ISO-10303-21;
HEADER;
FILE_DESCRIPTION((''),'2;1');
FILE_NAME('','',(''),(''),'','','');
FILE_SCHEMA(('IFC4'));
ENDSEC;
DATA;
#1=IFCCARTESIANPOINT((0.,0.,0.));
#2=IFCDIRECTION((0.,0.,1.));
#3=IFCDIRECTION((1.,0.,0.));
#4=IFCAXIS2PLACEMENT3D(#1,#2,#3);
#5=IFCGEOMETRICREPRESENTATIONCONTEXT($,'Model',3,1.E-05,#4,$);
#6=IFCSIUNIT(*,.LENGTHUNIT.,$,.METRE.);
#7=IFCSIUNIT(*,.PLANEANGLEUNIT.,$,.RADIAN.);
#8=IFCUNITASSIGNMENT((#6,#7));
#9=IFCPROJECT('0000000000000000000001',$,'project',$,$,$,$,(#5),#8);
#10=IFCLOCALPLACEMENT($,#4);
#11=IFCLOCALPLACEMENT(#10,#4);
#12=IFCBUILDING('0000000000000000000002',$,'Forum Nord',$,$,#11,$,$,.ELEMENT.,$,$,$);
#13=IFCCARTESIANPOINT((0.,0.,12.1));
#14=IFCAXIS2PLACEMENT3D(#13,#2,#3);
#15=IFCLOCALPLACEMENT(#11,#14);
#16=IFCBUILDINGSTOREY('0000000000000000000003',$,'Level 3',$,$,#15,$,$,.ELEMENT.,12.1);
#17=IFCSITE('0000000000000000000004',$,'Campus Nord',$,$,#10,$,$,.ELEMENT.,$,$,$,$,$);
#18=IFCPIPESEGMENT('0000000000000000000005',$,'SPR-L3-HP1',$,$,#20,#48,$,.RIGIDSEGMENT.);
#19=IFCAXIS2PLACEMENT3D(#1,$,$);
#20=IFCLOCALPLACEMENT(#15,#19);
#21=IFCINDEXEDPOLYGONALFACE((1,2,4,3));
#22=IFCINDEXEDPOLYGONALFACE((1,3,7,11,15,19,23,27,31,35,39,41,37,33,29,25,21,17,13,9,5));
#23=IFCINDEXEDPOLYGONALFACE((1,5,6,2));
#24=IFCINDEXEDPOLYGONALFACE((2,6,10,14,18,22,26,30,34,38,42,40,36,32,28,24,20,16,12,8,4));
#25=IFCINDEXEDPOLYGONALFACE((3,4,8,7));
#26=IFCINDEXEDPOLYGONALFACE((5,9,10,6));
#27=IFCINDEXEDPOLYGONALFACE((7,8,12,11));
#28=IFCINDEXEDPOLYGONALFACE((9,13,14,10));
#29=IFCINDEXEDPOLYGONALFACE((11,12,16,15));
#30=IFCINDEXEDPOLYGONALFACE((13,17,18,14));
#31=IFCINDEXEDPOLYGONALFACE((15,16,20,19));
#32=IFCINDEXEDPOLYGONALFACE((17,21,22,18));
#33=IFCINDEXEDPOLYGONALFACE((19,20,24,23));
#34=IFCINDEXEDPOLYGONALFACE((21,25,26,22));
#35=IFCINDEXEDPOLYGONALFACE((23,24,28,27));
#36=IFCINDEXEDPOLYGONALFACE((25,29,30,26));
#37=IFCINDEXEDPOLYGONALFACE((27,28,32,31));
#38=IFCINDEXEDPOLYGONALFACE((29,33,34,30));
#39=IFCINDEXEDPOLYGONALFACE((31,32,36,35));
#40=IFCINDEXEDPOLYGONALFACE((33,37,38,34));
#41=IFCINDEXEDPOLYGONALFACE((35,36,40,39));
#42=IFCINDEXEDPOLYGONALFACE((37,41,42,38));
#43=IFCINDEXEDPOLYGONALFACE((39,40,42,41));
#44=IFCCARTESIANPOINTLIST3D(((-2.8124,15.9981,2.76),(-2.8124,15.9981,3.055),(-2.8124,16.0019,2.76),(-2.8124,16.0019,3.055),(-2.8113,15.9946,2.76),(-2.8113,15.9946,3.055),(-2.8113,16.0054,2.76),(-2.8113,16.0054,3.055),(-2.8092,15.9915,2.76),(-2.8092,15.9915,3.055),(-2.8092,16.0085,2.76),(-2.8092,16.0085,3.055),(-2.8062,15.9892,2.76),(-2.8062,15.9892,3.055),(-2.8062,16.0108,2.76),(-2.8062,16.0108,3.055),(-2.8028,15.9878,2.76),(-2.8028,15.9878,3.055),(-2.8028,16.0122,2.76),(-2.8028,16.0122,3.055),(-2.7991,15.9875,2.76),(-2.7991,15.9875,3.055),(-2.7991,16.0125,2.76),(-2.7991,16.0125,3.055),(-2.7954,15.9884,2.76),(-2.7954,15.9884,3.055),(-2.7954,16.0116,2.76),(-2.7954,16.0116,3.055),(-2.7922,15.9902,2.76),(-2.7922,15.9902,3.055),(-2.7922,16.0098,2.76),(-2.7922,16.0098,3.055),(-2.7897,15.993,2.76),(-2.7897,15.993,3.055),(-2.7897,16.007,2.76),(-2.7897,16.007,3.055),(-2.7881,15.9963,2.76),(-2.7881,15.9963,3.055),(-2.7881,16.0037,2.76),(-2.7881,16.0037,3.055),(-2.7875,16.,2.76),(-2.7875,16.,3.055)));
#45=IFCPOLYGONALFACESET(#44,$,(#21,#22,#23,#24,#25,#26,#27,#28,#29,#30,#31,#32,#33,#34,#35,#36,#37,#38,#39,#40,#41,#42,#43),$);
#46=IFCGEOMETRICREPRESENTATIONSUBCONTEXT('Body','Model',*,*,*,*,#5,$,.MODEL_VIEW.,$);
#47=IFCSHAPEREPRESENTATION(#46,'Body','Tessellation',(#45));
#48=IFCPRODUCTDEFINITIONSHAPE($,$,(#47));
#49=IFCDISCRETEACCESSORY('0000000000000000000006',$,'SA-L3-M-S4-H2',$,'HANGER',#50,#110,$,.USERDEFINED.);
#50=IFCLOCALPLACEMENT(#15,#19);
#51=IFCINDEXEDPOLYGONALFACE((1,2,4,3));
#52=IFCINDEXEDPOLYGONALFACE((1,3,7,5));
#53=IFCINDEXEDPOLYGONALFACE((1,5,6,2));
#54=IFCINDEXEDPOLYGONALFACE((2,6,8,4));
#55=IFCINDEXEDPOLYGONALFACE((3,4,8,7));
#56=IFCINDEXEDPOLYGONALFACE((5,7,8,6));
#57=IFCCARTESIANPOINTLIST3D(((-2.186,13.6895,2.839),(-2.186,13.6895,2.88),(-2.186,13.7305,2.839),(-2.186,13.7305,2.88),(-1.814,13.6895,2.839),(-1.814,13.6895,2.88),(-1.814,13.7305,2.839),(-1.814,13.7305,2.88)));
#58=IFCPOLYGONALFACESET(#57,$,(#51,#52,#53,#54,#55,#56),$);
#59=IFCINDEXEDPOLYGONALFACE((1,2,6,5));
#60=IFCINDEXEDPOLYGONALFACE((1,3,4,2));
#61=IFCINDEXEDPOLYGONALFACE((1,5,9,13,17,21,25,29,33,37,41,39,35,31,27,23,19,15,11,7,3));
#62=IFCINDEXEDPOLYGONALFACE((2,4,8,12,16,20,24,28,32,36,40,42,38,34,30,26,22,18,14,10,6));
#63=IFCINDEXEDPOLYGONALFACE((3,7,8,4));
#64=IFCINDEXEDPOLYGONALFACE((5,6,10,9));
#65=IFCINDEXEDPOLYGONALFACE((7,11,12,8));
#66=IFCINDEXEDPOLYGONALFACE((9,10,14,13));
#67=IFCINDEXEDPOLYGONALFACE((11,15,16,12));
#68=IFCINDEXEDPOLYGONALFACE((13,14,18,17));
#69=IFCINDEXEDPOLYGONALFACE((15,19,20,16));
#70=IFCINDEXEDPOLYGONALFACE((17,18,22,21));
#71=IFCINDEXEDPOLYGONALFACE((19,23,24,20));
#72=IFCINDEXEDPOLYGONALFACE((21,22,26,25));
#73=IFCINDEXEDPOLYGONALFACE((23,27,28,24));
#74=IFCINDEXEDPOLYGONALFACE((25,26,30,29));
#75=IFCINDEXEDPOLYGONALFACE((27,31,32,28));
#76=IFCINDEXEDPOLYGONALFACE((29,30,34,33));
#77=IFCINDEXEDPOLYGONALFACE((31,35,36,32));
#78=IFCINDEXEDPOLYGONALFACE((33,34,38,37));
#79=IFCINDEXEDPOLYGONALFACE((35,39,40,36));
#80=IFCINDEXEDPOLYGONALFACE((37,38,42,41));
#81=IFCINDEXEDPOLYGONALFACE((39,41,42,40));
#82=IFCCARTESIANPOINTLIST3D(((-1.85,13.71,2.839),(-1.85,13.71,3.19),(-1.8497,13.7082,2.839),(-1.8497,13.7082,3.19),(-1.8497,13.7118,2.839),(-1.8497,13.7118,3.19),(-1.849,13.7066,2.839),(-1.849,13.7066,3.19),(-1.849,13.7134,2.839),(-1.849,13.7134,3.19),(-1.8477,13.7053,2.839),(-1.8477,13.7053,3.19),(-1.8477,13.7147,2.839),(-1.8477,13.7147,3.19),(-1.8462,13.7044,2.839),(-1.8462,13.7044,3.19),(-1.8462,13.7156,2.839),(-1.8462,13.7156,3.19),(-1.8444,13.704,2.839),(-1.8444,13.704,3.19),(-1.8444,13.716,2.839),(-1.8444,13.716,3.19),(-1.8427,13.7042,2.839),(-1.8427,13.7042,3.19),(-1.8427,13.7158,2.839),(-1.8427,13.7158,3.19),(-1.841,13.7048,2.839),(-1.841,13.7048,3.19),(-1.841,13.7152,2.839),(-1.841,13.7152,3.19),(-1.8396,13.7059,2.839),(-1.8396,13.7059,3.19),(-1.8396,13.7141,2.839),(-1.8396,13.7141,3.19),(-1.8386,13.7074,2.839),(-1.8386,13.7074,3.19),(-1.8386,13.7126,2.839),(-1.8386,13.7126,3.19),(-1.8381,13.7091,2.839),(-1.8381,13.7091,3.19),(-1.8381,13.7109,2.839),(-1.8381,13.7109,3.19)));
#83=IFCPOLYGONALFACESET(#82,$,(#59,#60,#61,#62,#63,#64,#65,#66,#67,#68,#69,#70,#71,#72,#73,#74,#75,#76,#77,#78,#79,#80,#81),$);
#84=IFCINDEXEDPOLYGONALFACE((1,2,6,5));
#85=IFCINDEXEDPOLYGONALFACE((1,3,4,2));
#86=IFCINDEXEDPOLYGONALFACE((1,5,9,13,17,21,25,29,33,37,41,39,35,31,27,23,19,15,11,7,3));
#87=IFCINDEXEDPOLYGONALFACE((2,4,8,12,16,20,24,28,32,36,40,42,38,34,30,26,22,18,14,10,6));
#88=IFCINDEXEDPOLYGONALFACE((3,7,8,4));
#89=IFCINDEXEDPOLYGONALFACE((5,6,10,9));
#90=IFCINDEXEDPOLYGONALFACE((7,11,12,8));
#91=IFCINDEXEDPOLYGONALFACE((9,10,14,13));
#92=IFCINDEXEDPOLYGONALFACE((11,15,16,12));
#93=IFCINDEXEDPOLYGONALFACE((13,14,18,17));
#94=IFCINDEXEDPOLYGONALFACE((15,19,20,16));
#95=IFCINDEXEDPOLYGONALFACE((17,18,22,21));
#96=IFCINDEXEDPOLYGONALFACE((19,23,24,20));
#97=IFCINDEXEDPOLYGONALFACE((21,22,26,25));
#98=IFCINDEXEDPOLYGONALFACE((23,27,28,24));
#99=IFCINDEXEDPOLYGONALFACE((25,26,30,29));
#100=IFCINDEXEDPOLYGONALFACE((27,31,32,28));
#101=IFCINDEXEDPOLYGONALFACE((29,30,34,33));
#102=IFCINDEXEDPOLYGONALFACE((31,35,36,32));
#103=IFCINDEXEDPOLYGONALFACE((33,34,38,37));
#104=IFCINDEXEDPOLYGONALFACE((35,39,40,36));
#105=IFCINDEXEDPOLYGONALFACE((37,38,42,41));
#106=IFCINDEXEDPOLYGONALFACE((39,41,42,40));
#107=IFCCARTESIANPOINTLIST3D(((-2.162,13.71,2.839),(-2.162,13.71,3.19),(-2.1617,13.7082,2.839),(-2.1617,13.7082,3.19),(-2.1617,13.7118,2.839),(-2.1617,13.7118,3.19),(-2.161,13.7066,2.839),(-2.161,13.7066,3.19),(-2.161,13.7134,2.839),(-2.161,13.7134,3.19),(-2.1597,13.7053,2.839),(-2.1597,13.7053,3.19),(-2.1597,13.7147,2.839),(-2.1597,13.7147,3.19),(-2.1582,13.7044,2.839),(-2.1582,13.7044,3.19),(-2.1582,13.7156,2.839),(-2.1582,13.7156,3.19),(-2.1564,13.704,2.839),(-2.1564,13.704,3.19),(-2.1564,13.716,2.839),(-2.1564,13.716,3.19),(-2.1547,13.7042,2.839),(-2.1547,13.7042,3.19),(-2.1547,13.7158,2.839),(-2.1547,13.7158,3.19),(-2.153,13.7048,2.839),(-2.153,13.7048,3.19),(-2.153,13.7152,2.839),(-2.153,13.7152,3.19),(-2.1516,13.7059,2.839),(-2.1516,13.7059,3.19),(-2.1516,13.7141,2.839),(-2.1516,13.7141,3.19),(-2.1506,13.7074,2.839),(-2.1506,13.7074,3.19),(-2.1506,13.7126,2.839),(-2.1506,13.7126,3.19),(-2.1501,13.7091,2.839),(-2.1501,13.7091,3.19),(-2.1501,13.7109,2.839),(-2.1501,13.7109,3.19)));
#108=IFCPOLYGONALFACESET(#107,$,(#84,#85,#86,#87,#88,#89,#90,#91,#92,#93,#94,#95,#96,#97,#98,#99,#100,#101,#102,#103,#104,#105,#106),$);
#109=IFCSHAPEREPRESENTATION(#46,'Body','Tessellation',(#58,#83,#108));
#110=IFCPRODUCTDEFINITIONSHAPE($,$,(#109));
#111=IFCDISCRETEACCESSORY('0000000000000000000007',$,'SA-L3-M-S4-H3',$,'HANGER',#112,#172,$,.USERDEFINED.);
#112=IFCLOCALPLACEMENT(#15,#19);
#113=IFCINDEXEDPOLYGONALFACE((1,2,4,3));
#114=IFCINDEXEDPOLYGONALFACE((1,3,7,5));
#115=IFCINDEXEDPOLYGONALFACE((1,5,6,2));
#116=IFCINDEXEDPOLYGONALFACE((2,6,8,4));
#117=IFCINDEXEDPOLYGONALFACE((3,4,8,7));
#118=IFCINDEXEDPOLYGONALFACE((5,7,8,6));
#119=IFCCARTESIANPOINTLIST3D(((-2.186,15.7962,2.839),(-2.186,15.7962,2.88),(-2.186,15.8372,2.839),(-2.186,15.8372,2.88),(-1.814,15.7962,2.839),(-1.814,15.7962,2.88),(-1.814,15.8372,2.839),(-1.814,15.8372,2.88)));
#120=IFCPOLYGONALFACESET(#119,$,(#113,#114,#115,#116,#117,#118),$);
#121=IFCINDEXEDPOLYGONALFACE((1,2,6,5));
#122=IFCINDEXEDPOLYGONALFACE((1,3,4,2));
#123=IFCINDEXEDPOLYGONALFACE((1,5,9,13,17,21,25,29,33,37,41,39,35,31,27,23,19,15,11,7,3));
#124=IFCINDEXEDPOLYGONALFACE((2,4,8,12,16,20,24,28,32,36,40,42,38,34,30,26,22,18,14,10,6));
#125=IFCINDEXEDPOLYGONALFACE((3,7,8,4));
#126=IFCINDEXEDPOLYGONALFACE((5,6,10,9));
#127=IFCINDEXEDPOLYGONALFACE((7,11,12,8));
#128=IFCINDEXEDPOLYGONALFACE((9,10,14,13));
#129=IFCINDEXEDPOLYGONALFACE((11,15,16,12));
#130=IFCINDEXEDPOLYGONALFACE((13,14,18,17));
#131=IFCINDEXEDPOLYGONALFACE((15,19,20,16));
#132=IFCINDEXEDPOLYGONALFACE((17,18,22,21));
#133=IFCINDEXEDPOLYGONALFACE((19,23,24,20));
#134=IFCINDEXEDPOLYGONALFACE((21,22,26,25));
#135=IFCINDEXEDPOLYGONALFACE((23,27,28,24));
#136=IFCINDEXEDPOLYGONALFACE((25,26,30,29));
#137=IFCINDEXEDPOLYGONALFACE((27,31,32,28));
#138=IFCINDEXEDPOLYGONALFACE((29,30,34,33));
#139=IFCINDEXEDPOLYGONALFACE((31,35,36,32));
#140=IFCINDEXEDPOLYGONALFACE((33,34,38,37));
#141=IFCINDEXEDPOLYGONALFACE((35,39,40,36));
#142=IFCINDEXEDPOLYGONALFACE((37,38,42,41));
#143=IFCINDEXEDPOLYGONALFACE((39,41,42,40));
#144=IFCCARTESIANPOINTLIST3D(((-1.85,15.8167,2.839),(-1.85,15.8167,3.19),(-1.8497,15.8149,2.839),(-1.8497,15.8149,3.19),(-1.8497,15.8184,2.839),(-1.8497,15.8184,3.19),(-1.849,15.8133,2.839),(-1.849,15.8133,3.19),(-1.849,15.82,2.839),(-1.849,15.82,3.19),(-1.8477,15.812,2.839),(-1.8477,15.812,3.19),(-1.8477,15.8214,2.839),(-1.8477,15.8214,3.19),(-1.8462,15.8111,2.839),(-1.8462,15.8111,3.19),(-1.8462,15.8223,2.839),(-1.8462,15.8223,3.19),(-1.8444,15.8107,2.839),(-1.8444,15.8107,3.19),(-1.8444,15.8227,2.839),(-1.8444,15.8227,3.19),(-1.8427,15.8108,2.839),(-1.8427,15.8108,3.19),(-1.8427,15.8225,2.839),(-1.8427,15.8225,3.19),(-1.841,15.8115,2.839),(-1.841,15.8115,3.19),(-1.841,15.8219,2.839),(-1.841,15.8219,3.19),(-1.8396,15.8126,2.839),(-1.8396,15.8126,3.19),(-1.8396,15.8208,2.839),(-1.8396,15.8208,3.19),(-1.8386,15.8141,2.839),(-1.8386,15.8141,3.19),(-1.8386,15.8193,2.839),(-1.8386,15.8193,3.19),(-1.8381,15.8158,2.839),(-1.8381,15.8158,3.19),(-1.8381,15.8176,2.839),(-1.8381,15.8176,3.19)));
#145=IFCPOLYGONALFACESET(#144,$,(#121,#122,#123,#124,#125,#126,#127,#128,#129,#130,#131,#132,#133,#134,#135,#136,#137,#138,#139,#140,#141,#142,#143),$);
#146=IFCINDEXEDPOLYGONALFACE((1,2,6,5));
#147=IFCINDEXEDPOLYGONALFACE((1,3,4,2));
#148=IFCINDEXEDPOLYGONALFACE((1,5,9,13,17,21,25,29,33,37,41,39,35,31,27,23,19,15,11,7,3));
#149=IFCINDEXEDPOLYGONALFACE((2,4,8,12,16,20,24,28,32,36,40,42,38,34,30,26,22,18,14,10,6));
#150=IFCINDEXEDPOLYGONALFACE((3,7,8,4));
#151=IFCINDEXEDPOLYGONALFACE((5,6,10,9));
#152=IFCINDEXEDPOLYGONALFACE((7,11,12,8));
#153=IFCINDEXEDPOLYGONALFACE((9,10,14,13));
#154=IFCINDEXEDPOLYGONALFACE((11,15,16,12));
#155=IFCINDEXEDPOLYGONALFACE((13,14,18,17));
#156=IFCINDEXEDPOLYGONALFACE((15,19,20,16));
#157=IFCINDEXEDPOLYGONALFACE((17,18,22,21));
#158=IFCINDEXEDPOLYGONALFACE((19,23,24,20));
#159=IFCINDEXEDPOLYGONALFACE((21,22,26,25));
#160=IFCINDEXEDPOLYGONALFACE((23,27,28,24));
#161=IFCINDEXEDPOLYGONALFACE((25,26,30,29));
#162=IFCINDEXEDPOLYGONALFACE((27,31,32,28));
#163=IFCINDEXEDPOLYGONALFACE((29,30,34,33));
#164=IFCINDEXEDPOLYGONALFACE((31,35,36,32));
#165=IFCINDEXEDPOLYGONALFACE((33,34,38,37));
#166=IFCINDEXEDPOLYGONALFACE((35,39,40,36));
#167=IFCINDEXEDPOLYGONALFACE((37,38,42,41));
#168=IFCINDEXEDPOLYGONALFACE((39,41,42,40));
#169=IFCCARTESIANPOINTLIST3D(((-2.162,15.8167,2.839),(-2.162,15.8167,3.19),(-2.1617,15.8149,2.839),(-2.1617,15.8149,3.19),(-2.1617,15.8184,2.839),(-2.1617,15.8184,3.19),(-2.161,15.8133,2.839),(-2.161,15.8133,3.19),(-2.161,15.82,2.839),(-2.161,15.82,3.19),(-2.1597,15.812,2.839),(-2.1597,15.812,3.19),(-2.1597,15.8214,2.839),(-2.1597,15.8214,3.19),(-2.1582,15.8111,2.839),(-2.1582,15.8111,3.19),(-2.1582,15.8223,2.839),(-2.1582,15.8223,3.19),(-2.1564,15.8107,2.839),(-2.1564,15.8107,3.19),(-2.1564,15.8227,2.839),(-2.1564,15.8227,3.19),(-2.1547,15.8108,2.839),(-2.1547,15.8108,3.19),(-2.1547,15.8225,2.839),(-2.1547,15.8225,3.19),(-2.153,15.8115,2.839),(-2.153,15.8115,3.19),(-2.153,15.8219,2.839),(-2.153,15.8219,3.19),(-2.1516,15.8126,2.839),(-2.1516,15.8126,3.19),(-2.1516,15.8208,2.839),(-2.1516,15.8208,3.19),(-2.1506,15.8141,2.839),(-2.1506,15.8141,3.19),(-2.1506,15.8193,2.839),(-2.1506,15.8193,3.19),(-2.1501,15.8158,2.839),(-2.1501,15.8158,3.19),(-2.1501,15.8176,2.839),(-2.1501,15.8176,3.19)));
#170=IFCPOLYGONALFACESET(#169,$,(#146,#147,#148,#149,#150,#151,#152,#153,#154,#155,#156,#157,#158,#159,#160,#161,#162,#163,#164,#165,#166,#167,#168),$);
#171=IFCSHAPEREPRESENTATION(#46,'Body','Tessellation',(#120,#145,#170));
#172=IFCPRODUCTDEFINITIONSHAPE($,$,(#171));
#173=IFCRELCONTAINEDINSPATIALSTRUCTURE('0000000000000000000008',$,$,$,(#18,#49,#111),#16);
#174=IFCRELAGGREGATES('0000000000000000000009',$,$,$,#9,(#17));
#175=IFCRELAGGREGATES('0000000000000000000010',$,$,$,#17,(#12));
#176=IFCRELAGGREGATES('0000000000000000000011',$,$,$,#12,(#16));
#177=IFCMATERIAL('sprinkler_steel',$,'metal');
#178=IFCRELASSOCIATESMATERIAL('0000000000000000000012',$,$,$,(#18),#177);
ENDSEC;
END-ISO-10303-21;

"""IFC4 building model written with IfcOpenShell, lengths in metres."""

from ifc_helpers import new_model, si_unit, frame, frame_2d, origin_with_axes, origin_2d_with_axis, place, context, subcontext, project, spatial, rectangle, circle, extrude, material, element, save


model = new_model("IFC4")

# Units and contexts
model_context = context("Model", 3, precision=1e-05, world=origin_with_axes())
body_context = subcontext(model_context, "Body", "Model", "MODEL_VIEW")
ifc_project = project(units=[si_unit("LENGTHUNIT", "METRE"), si_unit("PLANEANGLEUNIT", "RADIAN")], contexts=[model_context])

# Site, building, storey
site_placement = place(None, origin_with_axes())
site = spatial("IfcSite", under=ifc_project, at=site_placement, Name="Campus Nord", CompositionType="ELEMENT")
building_placement = place(site_placement, origin_with_axes())
building = spatial("IfcBuilding", under=site, at=building_placement, Name="Forum Nord", CompositionType="ELEMENT")
storey_placement = place(building_placement, frame((0.0, 0.0, 12.1), z_axis=(0.0, 0.0, 1.0), x_axis=(1.0, 0.0, 0.0)))
storey = spatial("IfcBuildingStorey", under=building, at=storey_placement, Name="Level 3", CompositionType="ELEMENT", Elevation=12.1)

# Shared definitions
ifc_material_1 = material(Name="sprinkler_steel", Category="metal")

# Pipe segment
pipe_segment_placement = place(storey_placement, frame((-2.8, 16.0, 3.055), z_axis=(0.0, 0.0, -1.0), x_axis=(1.0, 0.0, 0.0)))
element("IfcPipeSegment", 1, at=pipe_segment_placement, inside=storey, material=ifc_material_1, Name="SPR-L3-HP1", PredefinedType="RIGIDSEGMENT", context=body_context, shape_type="SweptSolid", body=[
    extrude(circle(Radius=0.0125, at=origin_2d_with_axis()), origin_with_axes(), (0.0, 0.0, 1.0), 0.295),
])

# Discrete accessories
for number, where, z_axis, x_axis, name in (
    (2, (-2.0, 13.71, 2.88), (0.0, 0.0, 1.0), (-1.0, 0.0, 0.0), "SA-L3-M-S4-H2"),
    (3, (-2.0, 15.8167, 2.88), (0.0, 0.0, 1.0), (-1.0, 0.0, 0.0), "SA-L3-M-S4-H3"),
):
    element("IfcDiscreteAccessory", number, at=place(storey_placement, frame(where, z_axis=z_axis, x_axis=x_axis)), inside=storey, Name=name, ObjectType="HANGER", PredefinedType="USERDEFINED", context=body_context, shape_type="SweptSolid", body=[
        extrude(rectangle(XDim=0.372, YDim=0.041, at=origin_2d_with_axis()), frame((0.0, 0.0, -0.041), z_axis=(0.0, 0.0, 1.0), x_axis=(1.0, 0.0, 0.0)), (0.0, 0.0, 1.0), 0.041),
        extrude(circle(Radius=0.006, at=frame_2d((-0.156, 0.0), x_axis=(1.0, 0.0))), frame((0.0, 0.0, -0.041), z_axis=(0.0, 0.0, 1.0), x_axis=(1.0, 0.0, 0.0)), (0.0, 0.0, 1.0), 0.351),
        extrude(circle(Radius=0.006, at=frame_2d((0.156, 0.0), x_axis=(1.0, 0.0))), frame((0.0, 0.0, -0.041), z_axis=(0.0, 0.0, 1.0), x_axis=(1.0, 0.0, 0.0)), (0.0, 0.0, 1.0), 0.351),
    ])

save(model, "model.ifc")
